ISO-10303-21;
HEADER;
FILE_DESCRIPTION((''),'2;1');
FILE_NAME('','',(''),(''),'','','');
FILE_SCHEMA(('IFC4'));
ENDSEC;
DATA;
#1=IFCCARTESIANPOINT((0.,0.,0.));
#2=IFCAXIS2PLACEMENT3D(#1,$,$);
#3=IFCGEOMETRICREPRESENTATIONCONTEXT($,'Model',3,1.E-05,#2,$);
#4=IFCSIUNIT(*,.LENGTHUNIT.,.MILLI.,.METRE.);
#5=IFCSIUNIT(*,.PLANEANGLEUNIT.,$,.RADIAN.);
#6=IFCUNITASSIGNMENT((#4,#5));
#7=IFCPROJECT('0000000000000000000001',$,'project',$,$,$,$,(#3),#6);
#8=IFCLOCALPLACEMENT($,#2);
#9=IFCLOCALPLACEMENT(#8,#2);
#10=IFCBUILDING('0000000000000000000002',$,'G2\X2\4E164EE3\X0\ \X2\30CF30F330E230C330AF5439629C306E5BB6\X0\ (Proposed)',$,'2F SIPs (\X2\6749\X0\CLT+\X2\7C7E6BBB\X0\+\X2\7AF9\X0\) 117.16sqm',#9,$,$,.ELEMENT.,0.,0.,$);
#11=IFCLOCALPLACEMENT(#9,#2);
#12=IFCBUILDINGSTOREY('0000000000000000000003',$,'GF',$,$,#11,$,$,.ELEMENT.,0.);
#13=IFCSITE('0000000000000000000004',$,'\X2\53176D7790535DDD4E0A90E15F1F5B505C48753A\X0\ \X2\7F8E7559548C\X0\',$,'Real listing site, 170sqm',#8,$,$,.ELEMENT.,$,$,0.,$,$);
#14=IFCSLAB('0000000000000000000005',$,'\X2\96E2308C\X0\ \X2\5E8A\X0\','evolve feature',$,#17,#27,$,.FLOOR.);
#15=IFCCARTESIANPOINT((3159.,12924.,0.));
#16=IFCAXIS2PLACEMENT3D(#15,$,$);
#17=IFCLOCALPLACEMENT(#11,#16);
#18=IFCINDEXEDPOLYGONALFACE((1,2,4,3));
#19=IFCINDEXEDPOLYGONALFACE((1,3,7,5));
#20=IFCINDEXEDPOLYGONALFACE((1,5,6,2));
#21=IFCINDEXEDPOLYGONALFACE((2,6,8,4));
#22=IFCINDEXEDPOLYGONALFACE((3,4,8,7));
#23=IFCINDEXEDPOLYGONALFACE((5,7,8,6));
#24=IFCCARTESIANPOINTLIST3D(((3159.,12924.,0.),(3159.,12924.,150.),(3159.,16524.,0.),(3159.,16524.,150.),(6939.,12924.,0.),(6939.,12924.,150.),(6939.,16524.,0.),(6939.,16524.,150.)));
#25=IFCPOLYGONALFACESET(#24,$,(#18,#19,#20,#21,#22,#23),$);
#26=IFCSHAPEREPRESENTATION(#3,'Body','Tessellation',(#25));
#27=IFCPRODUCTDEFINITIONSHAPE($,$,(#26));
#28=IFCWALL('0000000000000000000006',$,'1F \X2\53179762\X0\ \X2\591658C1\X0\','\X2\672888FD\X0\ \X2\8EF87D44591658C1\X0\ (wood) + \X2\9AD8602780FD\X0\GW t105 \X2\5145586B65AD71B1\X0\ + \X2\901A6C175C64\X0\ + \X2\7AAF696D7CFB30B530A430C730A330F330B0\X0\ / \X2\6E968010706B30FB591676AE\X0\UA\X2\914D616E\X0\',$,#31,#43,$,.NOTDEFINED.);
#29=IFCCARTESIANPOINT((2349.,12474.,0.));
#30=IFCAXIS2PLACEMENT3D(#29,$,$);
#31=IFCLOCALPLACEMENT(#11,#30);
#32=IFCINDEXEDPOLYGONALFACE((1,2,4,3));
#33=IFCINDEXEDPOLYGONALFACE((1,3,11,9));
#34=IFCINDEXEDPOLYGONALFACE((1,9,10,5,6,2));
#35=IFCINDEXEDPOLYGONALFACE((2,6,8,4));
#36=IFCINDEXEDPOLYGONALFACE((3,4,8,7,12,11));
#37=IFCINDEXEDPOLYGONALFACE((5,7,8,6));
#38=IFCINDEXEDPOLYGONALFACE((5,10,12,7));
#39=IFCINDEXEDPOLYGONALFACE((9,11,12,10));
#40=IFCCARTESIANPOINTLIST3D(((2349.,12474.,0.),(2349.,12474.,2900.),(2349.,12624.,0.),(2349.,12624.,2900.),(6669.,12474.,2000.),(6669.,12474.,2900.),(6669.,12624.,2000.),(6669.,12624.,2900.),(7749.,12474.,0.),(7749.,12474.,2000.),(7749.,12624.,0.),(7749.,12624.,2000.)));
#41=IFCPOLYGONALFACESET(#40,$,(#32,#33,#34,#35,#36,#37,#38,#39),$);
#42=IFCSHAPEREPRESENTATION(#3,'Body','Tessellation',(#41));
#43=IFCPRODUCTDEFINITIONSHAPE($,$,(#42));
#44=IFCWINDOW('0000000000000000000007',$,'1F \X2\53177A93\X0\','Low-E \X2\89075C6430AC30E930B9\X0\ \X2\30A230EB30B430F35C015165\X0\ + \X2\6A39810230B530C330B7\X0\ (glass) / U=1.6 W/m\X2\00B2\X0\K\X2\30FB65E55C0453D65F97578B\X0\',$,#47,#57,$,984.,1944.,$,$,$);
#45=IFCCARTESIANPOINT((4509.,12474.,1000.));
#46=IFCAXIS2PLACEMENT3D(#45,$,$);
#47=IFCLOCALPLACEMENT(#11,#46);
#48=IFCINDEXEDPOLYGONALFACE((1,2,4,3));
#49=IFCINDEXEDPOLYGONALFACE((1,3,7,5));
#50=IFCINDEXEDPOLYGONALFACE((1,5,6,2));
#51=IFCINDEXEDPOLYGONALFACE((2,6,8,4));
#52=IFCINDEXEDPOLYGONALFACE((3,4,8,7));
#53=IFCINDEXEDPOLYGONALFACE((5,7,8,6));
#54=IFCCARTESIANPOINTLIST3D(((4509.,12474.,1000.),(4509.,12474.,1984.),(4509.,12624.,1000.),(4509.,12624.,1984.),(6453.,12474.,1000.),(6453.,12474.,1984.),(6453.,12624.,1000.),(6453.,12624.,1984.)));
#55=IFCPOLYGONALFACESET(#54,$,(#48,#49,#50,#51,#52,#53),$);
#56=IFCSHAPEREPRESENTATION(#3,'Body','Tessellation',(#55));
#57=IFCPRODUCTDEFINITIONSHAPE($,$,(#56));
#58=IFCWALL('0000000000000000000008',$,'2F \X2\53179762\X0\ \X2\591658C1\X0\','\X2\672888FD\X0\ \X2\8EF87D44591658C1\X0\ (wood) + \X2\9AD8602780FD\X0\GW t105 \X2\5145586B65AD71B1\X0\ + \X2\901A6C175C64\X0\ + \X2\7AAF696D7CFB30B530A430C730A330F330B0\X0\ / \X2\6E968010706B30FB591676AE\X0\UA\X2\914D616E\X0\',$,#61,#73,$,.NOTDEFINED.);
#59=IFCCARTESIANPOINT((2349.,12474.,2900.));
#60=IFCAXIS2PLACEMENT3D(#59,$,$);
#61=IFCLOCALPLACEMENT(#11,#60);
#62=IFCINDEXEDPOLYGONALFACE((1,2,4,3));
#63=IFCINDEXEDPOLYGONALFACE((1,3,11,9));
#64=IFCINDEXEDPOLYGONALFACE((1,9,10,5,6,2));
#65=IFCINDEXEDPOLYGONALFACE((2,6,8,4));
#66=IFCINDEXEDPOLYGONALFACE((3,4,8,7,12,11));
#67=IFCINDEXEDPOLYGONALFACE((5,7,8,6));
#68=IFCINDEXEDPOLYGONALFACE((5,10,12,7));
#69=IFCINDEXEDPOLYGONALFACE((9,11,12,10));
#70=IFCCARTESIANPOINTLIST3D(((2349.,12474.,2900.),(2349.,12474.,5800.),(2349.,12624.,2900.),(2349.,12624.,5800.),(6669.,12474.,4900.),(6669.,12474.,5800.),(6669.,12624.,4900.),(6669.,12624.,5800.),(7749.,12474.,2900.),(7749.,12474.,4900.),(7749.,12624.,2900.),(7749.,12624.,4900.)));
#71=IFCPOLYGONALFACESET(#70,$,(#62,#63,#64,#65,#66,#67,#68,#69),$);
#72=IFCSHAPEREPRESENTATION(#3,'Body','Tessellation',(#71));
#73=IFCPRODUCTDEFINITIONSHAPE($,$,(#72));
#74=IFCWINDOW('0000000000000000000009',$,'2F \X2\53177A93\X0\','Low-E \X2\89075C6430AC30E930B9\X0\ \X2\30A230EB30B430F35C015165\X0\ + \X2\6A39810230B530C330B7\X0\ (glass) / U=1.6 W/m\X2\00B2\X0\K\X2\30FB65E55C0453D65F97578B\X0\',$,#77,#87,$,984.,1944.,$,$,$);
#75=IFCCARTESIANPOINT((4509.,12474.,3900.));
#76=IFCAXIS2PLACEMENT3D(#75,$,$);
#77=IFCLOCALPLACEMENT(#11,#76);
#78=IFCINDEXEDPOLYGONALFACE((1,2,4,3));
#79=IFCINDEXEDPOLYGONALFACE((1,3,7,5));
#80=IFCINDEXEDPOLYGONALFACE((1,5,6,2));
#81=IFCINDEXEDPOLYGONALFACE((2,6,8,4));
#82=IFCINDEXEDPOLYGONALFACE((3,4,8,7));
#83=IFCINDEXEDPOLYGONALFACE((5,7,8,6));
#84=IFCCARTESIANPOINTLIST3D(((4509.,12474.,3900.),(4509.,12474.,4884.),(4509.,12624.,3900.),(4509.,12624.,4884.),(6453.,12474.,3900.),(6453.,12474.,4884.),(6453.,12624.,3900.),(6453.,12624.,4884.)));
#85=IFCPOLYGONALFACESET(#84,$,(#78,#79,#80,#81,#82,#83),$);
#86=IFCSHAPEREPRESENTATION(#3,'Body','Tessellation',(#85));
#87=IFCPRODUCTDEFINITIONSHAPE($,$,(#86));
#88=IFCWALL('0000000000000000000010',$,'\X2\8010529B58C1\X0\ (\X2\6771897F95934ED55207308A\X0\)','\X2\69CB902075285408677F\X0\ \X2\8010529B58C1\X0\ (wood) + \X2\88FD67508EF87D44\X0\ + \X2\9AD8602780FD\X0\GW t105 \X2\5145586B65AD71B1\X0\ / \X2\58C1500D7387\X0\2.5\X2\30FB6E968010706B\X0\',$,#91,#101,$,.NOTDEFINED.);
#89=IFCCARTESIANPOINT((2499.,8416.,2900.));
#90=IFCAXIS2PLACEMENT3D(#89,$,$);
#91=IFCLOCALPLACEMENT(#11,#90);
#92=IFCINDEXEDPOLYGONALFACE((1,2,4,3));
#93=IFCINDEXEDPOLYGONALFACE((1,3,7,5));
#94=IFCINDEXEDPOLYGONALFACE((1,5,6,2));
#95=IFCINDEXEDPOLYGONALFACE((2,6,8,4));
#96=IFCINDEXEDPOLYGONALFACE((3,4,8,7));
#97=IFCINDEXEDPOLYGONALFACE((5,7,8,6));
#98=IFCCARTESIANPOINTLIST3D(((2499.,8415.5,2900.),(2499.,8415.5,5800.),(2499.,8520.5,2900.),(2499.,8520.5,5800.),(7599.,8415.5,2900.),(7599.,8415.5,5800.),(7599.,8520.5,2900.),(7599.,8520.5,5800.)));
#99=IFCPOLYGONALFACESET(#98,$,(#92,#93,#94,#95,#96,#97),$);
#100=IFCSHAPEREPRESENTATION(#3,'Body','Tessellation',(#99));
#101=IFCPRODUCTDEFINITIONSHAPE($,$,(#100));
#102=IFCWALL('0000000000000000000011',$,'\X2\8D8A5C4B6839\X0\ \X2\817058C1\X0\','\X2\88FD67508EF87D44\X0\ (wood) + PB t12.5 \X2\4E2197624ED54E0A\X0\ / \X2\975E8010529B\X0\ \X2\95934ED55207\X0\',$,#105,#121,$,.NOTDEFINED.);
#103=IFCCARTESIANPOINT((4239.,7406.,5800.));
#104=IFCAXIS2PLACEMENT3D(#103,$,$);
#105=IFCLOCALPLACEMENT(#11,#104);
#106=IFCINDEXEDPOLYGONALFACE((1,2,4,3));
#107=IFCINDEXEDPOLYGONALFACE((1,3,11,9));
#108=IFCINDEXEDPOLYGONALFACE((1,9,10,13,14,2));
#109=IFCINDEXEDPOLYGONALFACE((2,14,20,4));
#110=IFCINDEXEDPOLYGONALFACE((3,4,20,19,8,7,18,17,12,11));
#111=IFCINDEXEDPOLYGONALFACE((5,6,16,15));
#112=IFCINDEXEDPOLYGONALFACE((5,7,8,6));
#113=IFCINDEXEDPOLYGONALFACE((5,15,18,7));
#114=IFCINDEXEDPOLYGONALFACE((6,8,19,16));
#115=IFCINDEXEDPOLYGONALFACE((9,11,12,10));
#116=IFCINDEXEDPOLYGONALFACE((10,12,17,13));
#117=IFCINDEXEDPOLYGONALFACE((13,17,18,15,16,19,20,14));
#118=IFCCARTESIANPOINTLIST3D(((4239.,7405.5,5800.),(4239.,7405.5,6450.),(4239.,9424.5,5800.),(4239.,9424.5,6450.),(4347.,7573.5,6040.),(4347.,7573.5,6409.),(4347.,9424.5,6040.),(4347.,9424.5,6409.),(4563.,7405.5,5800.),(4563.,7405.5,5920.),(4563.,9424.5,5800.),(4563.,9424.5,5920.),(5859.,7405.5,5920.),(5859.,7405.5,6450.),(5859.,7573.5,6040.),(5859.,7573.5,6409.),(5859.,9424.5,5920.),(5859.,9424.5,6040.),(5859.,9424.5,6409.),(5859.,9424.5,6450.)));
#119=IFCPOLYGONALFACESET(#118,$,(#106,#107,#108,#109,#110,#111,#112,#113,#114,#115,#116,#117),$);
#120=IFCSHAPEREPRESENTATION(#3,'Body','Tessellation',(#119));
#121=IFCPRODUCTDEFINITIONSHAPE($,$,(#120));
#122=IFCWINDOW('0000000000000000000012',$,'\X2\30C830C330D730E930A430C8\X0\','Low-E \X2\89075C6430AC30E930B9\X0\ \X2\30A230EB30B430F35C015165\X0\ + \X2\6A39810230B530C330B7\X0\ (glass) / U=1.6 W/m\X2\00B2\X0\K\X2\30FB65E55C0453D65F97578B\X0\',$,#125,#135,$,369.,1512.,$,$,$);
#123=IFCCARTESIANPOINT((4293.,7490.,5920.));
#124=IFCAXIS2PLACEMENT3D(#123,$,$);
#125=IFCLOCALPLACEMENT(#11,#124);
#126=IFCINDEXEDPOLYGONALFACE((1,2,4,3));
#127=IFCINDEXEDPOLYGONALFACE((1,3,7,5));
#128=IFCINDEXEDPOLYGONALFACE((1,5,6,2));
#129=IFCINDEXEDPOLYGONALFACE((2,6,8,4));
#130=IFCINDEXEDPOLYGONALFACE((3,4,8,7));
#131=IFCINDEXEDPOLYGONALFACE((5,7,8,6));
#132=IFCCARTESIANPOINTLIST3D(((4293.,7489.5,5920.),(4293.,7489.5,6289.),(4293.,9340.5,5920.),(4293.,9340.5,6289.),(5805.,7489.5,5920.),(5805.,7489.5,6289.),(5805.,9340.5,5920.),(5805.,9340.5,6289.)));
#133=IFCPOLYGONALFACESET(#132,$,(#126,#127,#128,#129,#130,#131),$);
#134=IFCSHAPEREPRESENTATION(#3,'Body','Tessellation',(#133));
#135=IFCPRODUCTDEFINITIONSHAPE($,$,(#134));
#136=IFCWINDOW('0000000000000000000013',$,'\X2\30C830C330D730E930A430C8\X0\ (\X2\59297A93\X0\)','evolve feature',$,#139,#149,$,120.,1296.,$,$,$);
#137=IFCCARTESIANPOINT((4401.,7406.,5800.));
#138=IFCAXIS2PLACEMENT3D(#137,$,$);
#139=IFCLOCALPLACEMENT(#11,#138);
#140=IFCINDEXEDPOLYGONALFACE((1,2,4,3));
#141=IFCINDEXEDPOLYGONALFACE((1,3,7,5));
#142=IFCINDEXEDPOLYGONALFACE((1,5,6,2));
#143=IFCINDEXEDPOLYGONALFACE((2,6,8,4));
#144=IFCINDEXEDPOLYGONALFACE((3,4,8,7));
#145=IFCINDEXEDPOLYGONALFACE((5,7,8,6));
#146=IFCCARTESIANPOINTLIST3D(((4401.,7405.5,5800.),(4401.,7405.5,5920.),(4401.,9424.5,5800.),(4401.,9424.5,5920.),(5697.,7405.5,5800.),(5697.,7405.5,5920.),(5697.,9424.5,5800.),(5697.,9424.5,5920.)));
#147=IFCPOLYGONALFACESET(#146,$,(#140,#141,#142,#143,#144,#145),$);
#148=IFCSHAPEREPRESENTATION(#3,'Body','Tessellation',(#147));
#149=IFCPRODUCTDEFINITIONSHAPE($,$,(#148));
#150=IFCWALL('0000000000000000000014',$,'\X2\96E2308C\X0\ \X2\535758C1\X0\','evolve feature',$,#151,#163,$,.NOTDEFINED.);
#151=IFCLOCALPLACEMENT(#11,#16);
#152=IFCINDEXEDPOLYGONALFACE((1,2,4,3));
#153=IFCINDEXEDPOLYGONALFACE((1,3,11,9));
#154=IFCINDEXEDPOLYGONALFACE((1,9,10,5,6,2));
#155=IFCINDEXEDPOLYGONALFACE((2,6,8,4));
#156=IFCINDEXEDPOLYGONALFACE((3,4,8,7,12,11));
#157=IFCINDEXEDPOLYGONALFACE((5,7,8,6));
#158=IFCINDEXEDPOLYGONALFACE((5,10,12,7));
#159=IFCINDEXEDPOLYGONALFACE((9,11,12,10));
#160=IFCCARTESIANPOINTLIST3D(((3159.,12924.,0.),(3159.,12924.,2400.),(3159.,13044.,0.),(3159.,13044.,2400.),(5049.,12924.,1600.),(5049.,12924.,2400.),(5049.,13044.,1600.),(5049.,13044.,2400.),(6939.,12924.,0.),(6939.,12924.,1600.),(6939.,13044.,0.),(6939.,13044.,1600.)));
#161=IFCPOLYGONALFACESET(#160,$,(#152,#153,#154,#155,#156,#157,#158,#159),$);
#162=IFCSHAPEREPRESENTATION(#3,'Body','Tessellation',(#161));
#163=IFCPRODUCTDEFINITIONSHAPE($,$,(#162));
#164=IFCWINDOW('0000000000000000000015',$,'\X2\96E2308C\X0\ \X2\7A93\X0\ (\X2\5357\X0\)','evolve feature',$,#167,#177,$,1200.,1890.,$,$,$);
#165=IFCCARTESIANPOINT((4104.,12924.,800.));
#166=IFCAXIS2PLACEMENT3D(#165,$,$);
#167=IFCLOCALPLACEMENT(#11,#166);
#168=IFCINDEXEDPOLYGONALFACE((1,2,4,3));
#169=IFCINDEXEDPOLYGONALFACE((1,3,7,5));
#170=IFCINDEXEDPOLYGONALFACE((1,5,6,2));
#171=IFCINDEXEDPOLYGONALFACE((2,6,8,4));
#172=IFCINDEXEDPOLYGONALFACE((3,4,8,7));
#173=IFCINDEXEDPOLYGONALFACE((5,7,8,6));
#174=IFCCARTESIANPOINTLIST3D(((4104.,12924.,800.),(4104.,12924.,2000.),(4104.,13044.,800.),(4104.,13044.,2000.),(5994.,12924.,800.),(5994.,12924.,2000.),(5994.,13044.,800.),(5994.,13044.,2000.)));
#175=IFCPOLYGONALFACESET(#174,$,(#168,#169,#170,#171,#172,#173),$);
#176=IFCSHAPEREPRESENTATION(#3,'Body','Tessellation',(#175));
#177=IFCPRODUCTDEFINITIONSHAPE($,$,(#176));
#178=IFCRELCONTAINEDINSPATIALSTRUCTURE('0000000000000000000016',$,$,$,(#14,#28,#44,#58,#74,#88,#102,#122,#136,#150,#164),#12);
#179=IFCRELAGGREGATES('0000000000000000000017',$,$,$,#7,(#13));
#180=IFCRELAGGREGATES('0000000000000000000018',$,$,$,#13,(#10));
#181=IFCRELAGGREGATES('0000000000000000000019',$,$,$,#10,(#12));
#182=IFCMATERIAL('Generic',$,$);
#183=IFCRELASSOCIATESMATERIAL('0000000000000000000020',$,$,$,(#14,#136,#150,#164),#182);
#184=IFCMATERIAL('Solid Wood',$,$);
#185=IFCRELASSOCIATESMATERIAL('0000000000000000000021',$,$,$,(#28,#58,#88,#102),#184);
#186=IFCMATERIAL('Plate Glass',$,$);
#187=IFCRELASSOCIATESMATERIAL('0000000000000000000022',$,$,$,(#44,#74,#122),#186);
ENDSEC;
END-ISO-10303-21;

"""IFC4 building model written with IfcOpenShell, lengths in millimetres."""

from ifc_helpers import new_model, si_unit, frame, frame_2d, origin, place, context, project, spatial, rectangle, extrude, material, element, fill, save


model = new_model("IFC4")

# Units and contexts
model_context = context("Model", 3, precision=1e-05, world=origin())
ifc_project = project(units=[si_unit("LENGTHUNIT", "METRE", prefix="MILLI"), si_unit("PLANEANGLEUNIT", "RADIAN")], contexts=[model_context])

# Site, building, storey
site_placement = place(None, origin())
site = spatial("IfcSite", under=ifc_project, at=site_placement, Name="北海道川上郡弟子屈町 美留和", ObjectType="Real listing site, 170sqm", CompositionType="ELEMENT", RefElevation=0.0)
building_placement = place(site_placement, origin())
building = spatial("IfcBuilding", under=site, at=building_placement, Name="G2世代 ハンモック吹抜の家 (Proposed)", ObjectType="2F SIPs (杉CLT+籾殻+竹) 117.16sqm", CompositionType="ELEMENT", ElevationOfRefHeight=0.0, ElevationOfTerrain=0.0)
storey_placement = place(building_placement, origin())
storey = spatial("IfcBuildingStorey", under=building, at=storey_placement, Name="GF", CompositionType="ELEMENT", Elevation=0.0)

# Slab
ifc_material_1 = material(Name="Generic")
slab_placement = place(storey_placement, frame((3159.0, 12924.0, 0.0)))
element("IfcSlab", 1, at=slab_placement, inside=storey, material=ifc_material_1, Name="離れ 床", Description="evolve feature", PredefinedType="FLOOR", context=model_context, shape_type="SweptSolid", body=[
    extrude(rectangle(XDim=3780.0, YDim=3600.0, at=frame_2d((1890.0, 1800.0))), frame((3159.0, 12924.0, 0.0)), (0.0, 0.0, 1.0), 150.0),
])

# Wall, opening, window
ifc_material_2 = material(Name="Solid Wood")
wall_1_placement = place(storey_placement, frame((2349.0, 12474.0, 0.0)))
wall_1 = element("IfcWall", 2, at=wall_1_placement, inside=storey, material=ifc_material_2, Name="1F 北面 外壁", Description="木製 軸組外壁 (wood) + 高性能GW t105 充填断熱 + 通気層 + 窯業系サイディング / 準耐火・外皮UA配慮", PredefinedType="NOTDEFINED", context=model_context, shape_type="SweptSolid", body=[
    extrude(rectangle(XDim=5400.0, YDim=150.0, at=frame_2d((2700.0, 75.0))), frame((2349.0, 12474.0, 0.0)), (0.0, 0.0, 1.0), 2900.0),
])
opening_1_placement = place(storey_placement, frame((4509.0, 12474.0, 1000.0)))
opening_1 = element("IfcOpeningElement", 3, at=opening_1_placement, cuts=wall_1, PredefinedType="NOTDEFINED", context=model_context, shape_type="SweptSolid", body=[
    extrude(rectangle(XDim=1944.0, YDim=150.0, at=frame_2d((972.0, 75.0))), frame((4509.0, 12474.0, 1000.0)), (0.0, 0.0, 1.0), 984.0),
])
ifc_material_3 = material(Name="Plate Glass")
window_1_placement = place(storey_placement, frame((4509.0, 12474.0, 1000.0)))
window_1 = element("IfcWindow", 4, at=window_1_placement, inside=storey, material=ifc_material_3, Name="1F 北窓", Description="Low-E 複層ガラス アルゴン封入 + 樹脂サッシ (glass) / U=1.6 W/m²K・日射取得型", OverallHeight=984.0, OverallWidth=1944.0, context=model_context, shape_type="SweptSolid", body=[
    extrude(rectangle(XDim=1944.0, YDim=150.0, at=frame_2d((972.0, 75.0))), frame((4509.0, 12474.0, 1000.0)), (0.0, 0.0, 1.0), 984.0),
])
fill(opening_1, window_1)

# Wall, opening, window
wall_2_placement = place(storey_placement, frame((2349.0, 12474.0, 2900.0)))
wall_2 = element("IfcWall", 5, at=wall_2_placement, inside=storey, material=ifc_material_2, Name="2F 北面 外壁", Description="木製 軸組外壁 (wood) + 高性能GW t105 充填断熱 + 通気層 + 窯業系サイディング / 準耐火・外皮UA配慮", PredefinedType="NOTDEFINED", context=model_context, shape_type="SweptSolid", body=[
    extrude(rectangle(XDim=5400.0, YDim=150.0, at=frame_2d((2700.0, 75.0))), frame((2349.0, 12474.0, 2900.0)), (0.0, 0.0, 1.0), 2900.0),
])
opening_2_placement = place(storey_placement, frame((4509.0, 12474.0, 3900.0)))
opening_2 = element("IfcOpeningElement", 6, at=opening_2_placement, cuts=wall_2, PredefinedType="NOTDEFINED", context=model_context, shape_type="SweptSolid", body=[
    extrude(rectangle(XDim=1944.0, YDim=150.0, at=frame_2d((972.0, 75.0))), frame((4509.0, 12474.0, 3900.0)), (0.0, 0.0, 1.0), 984.0),
])
window_2_placement = place(storey_placement, frame((4509.0, 12474.0, 3900.0)))
window_2 = element("IfcWindow", 7, at=window_2_placement, inside=storey, material=ifc_material_3, Name="2F 北窓", Description="Low-E 複層ガラス アルゴン封入 + 樹脂サッシ (glass) / U=1.6 W/m²K・日射取得型", OverallHeight=984.0, OverallWidth=1944.0, context=model_context, shape_type="SweptSolid", body=[
    extrude(rectangle(XDim=1944.0, YDim=150.0, at=frame_2d((972.0, 75.0))), frame((4509.0, 12474.0, 3900.0)), (0.0, 0.0, 1.0), 984.0),
])
fill(opening_2, window_2)

# Wall
wall_3_placement = place(storey_placement, frame((2499.0, 8416.0, 2900.0)))
element("IfcWall", 8, at=wall_3_placement, inside=storey, material=ifc_material_2, Name="耐力壁 (東西間仕切り)", Description="構造用合板 耐力壁 (wood) + 製材軸組 + 高性能GW t105 充填断熱 / 壁倍率2.5・準耐火", PredefinedType="NOTDEFINED", context=model_context, shape_type="SweptSolid", body=[
    extrude(rectangle(XDim=5100.0, YDim=105.0, at=frame_2d((2550.0, 52.0))), frame((2499.0, 8416.0, 2900.0)), (0.0, 0.0, 1.0), 2900.0),
])

# Wall, openings, windows
wall_4_placement = place(storey_placement, frame((4239.0, 7406.0, 5800.0)))
wall_4 = element("IfcWall", 9, at=wall_4_placement, inside=storey, material=ifc_material_2, Name="越屋根 腰壁", Description="製材軸組 (wood) + PB t12.5 両面仕上 / 非耐力 間仕切", PredefinedType="NOTDEFINED", context=model_context, shape_type="SweptSolid", body=[
    extrude(rectangle(XDim=1620.0, YDim=2019.0, at=frame_2d((810.0, 1009.0))), frame((4239.0, 7406.0, 5800.0)), (0.0, 0.0, 1.0), 650.0),
])
opening_3_placement = place(storey_placement, frame((4293.0, 7490.0, 5920.0)))
opening_3 = element("IfcOpeningElement", 10, at=opening_3_placement, cuts=wall_4, PredefinedType="NOTDEFINED", context=model_context, shape_type="SweptSolid", body=[
    extrude(rectangle(XDim=1512.0, YDim=1851.0, at=frame_2d((756.0, 925.0))), frame((4293.0, 7490.0, 5920.0)), (0.0, 0.0, 1.0), 369.0),
])
opening_4_placement = place(storey_placement, frame((4401.0, 7406.0, 5800.0)))
opening_4 = element("IfcOpeningElement", 11, at=opening_4_placement, cuts=wall_4, PredefinedType="NOTDEFINED", context=model_context, shape_type="SweptSolid", body=[
    extrude(rectangle(XDim=1296.0, YDim=2019.0, at=frame_2d((648.0, 1009.0))), frame((4401.0, 7406.0, 5800.0)), (0.0, 0.0, 1.0), 120.0),
])
window_3_placement = place(storey_placement, frame((4293.0, 7490.0, 5920.0)))
window_3 = element("IfcWindow", 12, at=window_3_placement, inside=storey, material=ifc_material_3, Name="トップライト", Description="Low-E 複層ガラス アルゴン封入 + 樹脂サッシ (glass) / U=1.6 W/m²K・日射取得型", OverallHeight=369.0, OverallWidth=1512.0, context=model_context, shape_type="SweptSolid", body=[
    extrude(rectangle(XDim=1512.0, YDim=1851.0, at=frame_2d((756.0, 925.0))), frame((4293.0, 7490.0, 5920.0)), (0.0, 0.0, 1.0), 369.0),
])
fill(opening_3, window_3)
window_4_placement = place(storey_placement, frame((4401.0, 7406.0, 5800.0)))
window_4 = element("IfcWindow", 13, at=window_4_placement, inside=storey, material=ifc_material_1, Name="トップライト (天窓)", Description="evolve feature", OverallHeight=120.0, OverallWidth=1296.0, context=model_context, shape_type="SweptSolid", body=[
    extrude(rectangle(XDim=1296.0, YDim=2019.0, at=frame_2d((648.0, 1009.0))), frame((4401.0, 7406.0, 5800.0)), (0.0, 0.0, 1.0), 120.0),
])
fill(opening_4, window_4)

# Wall, opening, window
wall_5_placement = place(storey_placement, frame((3159.0, 12924.0, 0.0)))
wall_5 = element("IfcWall", 14, at=wall_5_placement, inside=storey, material=ifc_material_1, Name="離れ 南壁", Description="evolve feature", PredefinedType="NOTDEFINED", context=model_context, shape_type="SweptSolid", body=[
    extrude(rectangle(XDim=3780.0, YDim=120.0, at=frame_2d((1890.0, 60.0))), frame((3159.0, 12924.0, 0.0)), (0.0, 0.0, 1.0), 2400.0),
])
opening_5_placement = place(storey_placement, frame((4104.0, 12924.0, 800.0)))
opening_5 = element("IfcOpeningElement", 15, at=opening_5_placement, cuts=wall_5, PredefinedType="NOTDEFINED", context=model_context, shape_type="SweptSolid", body=[
    extrude(rectangle(XDim=1890.0, YDim=120.0, at=frame_2d((945.0, 60.0))), frame((4104.0, 12924.0, 800.0)), (0.0, 0.0, 1.0), 1200.0),
])
window_5_placement = place(storey_placement, frame((4104.0, 12924.0, 800.0)))
window_5 = element("IfcWindow", 16, at=window_5_placement, inside=storey, material=ifc_material_1, Name="離れ 窓 (南)", Description="evolve feature", OverallHeight=1200.0, OverallWidth=1890.0, context=model_context, shape_type="SweptSolid", body=[
    extrude(rectangle(XDim=1890.0, YDim=120.0, at=frame_2d((945.0, 60.0))), frame((4104.0, 12924.0, 800.0)), (0.0, 0.0, 1.0), 1200.0),
])
fill(opening_5, window_5)

save(model, "model.ifc")
